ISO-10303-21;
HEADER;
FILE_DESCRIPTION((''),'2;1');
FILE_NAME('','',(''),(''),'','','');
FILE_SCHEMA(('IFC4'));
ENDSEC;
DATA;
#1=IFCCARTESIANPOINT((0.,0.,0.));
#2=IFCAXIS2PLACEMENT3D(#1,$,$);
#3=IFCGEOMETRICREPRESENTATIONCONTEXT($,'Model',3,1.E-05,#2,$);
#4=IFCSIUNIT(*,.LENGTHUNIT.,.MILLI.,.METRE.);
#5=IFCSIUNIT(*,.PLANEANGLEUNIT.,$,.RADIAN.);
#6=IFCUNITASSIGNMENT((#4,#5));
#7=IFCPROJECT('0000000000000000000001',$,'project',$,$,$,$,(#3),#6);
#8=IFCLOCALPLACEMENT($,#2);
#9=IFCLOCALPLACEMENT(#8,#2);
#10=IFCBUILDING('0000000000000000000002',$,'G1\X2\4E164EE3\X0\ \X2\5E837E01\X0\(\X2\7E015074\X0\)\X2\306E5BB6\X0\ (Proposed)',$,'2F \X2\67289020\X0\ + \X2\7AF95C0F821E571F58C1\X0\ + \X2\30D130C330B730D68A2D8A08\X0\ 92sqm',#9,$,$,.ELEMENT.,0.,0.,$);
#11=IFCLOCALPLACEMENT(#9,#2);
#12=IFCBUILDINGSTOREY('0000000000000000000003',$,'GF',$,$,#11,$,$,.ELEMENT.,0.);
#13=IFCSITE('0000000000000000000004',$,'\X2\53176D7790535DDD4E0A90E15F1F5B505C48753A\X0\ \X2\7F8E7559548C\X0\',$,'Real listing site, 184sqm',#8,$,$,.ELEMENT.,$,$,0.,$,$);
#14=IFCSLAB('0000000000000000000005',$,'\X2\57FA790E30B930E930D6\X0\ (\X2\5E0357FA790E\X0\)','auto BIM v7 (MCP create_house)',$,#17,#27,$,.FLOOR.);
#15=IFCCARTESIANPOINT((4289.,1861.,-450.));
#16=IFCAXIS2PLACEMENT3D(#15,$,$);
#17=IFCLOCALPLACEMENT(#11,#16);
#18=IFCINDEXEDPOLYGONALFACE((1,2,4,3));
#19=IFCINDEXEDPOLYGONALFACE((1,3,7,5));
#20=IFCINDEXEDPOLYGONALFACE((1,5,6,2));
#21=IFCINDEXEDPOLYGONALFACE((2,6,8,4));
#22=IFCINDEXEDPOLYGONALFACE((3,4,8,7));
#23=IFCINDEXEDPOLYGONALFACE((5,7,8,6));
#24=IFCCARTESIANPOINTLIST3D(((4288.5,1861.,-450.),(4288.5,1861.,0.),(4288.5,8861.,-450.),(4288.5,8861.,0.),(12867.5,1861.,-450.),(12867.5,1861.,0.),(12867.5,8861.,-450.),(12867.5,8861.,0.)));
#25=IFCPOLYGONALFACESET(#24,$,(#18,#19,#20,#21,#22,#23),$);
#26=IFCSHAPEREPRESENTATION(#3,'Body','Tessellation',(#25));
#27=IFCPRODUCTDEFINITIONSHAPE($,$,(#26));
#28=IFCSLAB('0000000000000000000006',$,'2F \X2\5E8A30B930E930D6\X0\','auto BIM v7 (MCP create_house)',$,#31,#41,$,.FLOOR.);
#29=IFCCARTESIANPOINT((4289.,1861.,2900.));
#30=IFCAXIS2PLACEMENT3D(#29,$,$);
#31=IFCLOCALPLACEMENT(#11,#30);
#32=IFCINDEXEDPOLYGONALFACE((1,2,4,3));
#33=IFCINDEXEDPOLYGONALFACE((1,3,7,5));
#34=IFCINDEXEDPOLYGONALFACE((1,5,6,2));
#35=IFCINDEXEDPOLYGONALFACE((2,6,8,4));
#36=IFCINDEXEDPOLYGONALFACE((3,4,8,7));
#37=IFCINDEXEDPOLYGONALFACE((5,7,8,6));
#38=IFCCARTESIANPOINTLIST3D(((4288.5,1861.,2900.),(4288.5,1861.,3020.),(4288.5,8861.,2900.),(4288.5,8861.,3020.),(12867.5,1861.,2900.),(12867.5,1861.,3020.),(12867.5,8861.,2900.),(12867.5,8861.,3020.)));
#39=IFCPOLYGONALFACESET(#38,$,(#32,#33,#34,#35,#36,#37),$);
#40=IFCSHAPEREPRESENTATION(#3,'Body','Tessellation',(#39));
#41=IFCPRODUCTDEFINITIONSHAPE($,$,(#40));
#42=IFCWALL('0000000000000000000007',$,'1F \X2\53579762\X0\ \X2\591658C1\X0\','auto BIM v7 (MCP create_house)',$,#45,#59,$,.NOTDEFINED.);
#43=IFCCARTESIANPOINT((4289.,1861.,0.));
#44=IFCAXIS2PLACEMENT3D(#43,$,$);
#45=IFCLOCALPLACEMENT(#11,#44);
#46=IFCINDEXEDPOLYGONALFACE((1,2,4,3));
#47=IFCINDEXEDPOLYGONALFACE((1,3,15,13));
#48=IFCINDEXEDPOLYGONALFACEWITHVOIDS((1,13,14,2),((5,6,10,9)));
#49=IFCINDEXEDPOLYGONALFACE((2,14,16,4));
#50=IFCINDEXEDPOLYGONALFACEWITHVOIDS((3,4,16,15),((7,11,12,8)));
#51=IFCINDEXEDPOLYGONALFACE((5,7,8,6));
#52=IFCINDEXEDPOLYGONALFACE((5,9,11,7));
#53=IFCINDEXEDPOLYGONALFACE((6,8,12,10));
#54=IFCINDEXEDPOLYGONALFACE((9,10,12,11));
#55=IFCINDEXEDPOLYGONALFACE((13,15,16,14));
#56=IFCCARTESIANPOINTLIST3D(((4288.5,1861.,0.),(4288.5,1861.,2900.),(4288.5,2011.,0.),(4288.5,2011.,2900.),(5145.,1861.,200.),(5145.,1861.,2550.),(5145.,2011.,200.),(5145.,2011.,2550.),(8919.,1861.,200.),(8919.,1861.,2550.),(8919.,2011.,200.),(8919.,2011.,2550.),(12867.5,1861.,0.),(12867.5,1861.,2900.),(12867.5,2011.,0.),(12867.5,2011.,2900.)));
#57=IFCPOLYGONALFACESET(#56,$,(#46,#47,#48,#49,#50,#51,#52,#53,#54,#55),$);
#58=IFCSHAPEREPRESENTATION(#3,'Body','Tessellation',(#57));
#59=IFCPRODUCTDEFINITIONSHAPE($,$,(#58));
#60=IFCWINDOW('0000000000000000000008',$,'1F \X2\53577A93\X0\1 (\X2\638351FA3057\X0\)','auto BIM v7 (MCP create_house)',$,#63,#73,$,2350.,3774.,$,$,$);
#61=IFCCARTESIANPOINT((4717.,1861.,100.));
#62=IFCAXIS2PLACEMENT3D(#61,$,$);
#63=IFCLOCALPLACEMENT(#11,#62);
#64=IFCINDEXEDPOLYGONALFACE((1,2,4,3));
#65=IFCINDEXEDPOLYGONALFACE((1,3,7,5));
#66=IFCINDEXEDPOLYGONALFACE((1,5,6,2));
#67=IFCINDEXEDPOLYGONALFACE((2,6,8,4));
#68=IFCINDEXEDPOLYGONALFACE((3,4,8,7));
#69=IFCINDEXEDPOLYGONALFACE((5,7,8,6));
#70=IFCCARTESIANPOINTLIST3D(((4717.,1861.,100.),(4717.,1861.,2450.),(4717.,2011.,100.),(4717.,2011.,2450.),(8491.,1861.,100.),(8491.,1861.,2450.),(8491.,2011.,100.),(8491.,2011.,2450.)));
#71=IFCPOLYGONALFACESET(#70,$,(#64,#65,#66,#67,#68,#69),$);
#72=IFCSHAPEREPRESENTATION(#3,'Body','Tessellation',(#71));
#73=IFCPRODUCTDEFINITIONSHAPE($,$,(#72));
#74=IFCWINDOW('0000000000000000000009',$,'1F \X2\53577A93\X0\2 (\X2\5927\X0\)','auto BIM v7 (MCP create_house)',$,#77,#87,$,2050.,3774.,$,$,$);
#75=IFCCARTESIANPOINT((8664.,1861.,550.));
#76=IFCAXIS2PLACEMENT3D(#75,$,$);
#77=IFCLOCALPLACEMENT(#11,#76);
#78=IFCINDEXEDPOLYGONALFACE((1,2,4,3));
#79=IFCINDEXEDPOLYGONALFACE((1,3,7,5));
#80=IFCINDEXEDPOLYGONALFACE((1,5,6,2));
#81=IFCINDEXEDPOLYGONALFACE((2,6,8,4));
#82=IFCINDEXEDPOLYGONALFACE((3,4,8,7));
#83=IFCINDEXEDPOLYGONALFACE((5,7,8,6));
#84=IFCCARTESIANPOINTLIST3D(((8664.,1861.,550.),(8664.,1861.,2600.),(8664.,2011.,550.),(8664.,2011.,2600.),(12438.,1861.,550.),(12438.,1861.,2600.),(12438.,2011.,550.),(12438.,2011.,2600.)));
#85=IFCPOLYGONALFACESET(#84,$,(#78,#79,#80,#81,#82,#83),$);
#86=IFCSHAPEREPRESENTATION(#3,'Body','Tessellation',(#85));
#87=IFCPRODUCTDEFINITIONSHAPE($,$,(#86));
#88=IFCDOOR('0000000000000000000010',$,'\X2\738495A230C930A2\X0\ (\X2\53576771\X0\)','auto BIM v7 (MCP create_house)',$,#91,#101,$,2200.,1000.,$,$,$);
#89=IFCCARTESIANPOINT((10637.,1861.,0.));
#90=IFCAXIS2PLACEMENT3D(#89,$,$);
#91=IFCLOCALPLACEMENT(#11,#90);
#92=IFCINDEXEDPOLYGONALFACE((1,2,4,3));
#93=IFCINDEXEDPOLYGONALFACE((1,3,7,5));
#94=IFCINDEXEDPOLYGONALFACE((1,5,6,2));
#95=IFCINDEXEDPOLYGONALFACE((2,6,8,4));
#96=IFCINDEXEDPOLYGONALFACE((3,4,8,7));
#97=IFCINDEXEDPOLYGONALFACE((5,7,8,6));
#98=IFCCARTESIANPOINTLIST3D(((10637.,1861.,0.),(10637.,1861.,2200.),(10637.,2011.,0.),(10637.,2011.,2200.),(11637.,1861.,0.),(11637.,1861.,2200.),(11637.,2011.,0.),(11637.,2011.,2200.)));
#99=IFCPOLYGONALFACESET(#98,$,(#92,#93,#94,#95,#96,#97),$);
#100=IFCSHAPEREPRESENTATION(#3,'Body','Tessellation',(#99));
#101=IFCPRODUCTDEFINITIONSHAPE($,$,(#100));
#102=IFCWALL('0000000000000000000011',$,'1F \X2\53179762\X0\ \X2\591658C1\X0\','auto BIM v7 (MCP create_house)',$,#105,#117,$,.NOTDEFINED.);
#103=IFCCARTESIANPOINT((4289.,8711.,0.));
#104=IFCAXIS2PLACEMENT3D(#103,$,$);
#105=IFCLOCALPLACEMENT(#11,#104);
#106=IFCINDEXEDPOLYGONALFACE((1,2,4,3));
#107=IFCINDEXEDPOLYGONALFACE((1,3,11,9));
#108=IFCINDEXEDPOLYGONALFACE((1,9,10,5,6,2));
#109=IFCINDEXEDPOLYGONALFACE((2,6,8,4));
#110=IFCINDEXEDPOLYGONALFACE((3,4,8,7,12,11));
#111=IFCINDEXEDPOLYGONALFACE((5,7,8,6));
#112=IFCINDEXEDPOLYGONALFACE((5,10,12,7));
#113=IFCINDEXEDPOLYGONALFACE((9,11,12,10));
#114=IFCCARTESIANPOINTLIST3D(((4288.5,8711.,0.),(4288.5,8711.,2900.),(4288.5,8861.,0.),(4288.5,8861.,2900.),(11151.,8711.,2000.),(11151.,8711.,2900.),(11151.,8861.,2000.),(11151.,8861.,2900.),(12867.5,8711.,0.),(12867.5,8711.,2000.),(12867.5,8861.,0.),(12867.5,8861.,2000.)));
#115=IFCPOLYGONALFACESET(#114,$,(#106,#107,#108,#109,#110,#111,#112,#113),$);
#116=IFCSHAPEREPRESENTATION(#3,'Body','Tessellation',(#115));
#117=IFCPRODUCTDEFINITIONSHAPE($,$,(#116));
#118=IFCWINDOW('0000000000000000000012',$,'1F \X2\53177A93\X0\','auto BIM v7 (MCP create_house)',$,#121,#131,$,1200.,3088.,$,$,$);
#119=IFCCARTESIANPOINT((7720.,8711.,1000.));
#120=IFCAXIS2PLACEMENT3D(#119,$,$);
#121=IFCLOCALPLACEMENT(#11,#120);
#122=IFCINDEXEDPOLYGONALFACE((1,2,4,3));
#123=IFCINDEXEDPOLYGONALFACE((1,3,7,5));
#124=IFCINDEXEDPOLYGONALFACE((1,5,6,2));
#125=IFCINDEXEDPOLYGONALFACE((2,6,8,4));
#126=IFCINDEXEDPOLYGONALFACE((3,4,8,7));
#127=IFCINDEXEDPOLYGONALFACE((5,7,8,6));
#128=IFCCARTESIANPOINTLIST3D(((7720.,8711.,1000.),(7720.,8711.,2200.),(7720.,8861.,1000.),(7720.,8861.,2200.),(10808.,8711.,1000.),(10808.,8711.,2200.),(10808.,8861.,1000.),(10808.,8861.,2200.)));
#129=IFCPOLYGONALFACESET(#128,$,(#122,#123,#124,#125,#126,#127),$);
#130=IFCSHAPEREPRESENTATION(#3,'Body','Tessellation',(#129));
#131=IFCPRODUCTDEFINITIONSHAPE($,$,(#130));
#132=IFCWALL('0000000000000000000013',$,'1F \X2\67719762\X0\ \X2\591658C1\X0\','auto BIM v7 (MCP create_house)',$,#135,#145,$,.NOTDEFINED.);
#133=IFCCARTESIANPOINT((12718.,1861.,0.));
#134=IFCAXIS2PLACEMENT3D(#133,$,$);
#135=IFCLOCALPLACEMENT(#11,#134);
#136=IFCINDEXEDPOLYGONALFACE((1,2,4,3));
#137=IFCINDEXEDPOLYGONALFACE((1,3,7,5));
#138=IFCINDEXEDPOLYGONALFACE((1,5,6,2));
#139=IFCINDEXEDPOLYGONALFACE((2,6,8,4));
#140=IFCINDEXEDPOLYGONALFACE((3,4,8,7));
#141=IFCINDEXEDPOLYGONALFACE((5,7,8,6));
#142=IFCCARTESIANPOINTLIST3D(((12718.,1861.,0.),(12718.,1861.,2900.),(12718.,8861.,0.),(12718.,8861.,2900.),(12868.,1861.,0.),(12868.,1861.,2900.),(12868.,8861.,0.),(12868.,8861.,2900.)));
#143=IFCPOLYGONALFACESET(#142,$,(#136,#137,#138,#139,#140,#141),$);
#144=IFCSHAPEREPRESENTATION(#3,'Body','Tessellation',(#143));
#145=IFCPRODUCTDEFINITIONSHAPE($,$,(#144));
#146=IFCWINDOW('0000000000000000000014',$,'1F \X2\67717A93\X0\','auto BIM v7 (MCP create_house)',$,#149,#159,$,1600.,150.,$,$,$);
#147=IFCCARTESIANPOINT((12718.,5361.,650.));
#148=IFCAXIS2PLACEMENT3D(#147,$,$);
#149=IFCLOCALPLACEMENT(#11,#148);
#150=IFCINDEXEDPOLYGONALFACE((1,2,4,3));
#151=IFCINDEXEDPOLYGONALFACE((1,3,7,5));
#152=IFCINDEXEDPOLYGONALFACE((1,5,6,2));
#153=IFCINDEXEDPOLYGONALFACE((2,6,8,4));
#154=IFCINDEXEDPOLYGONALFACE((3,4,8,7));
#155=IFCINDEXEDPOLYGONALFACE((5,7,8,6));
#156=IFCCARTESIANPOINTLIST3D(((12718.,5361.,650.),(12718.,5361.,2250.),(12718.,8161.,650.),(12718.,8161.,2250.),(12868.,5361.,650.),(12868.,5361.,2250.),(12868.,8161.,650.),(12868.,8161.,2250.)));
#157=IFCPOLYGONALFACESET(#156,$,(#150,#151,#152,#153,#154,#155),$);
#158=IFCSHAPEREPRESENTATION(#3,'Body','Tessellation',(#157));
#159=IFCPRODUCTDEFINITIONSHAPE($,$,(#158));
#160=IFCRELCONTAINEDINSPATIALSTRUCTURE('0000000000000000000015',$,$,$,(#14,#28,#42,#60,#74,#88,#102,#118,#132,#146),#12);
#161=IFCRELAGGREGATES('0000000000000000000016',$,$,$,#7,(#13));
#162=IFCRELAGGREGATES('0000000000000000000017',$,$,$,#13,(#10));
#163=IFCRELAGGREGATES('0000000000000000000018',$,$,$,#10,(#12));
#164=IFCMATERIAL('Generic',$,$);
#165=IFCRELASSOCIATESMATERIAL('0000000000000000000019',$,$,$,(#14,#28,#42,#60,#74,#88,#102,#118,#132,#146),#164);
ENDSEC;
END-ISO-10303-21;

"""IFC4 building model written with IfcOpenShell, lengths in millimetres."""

from ifc_helpers import new_model, si_unit, frame, frame_2d, origin, place, context, project, spatial, rectangle, extrude, material, element, fill, save


model = new_model("IFC4")

# Units and contexts
model_context = context("Model", 3, precision=1e-05, world=origin())
ifc_project = project(units=[si_unit("LENGTHUNIT", "METRE", prefix="MILLI"), si_unit("PLANEANGLEUNIT", "RADIAN")], contexts=[model_context])

# Site, building, storey
site_placement = place(None, origin())
site = spatial("IfcSite", under=ifc_project, at=site_placement, Name="北海道川上郡弟子屈町 美留和", ObjectType="Real listing site, 184sqm", CompositionType="ELEMENT", RefElevation=0.0)
building_placement = place(site_placement, origin())
building = spatial("IfcBuilding", under=site, at=building_placement, Name="G1世代 広縁(縁側)の家 (Proposed)", ObjectType="2F 木造 + 竹小舞土壁 + パッシブ設計 92sqm", CompositionType="ELEMENT", ElevationOfRefHeight=0.0, ElevationOfTerrain=0.0)
storey_placement = place(building_placement, origin())
storey = spatial("IfcBuildingStorey", under=building, at=storey_placement, Name="GF", CompositionType="ELEMENT", Elevation=0.0)

# Slabs
ifc_material = material(Name="Generic")
slab_1_placement = place(storey_placement, frame((4289.0, 1861.0, -450.0)))
element("IfcSlab", 1, at=slab_1_placement, inside=storey, material=ifc_material, Name="基礎スラブ (布基礎)", Description="auto BIM v7 (MCP create_house)", PredefinedType="FLOOR", context=model_context, shape_type="SweptSolid", body=[
    extrude(rectangle(XDim=8579.0, YDim=7000.0, at=frame_2d((4289.0, 3500.0))), frame((4289.0, 1861.0, -450.0)), (0.0, 0.0, 1.0), 450.0),
])
slab_2_placement = place(storey_placement, frame((4289.0, 1861.0, 2900.0)))
element("IfcSlab", 2, at=slab_2_placement, inside=storey, material=ifc_material, Name="2F 床スラブ", Description="auto BIM v7 (MCP create_house)", PredefinedType="FLOOR", context=model_context, shape_type="SweptSolid", body=[
    extrude(rectangle(XDim=8579.0, YDim=7000.0, at=frame_2d((4289.0, 3500.0))), frame((4289.0, 1861.0, 2900.0)), (0.0, 0.0, 1.0), 120.0),
])

# Wall, openings, windows, door
wall_1_placement = place(storey_placement, frame((4289.0, 1861.0, 0.0)))
wall_1 = element("IfcWall", 3, at=wall_1_placement, inside=storey, material=ifc_material, Name="1F 南面 外壁", Description="auto BIM v7 (MCP create_house)", PredefinedType="NOTDEFINED", context=model_context, shape_type="SweptSolid", body=[
    extrude(rectangle(XDim=8579.0, YDim=150.0, at=frame_2d((4289.0, 75.0))), frame((4289.0, 1861.0, 0.0)), (0.0, 0.0, 1.0), 2900.0),
])
opening_1_placement = place(storey_placement, frame((4717.0, 1861.0, 100.0)))
opening_1 = element("IfcOpeningElement", 4, at=opening_1_placement, cuts=wall_1, PredefinedType="NOTDEFINED", context=model_context, shape_type="SweptSolid", body=[
    extrude(rectangle(XDim=3774.0, YDim=150.0, at=frame_2d((1887.0, 75.0))), frame((4717.0, 1861.0, 100.0)), (0.0, 0.0, 1.0), 2350.0),
])
opening_2_placement = place(storey_placement, frame((8664.0, 1861.0, 550.0)))
opening_2 = element("IfcOpeningElement", 5, at=opening_2_placement, cuts=wall_1, PredefinedType="NOTDEFINED", context=model_context, shape_type="SweptSolid", body=[
    extrude(rectangle(XDim=3774.0, YDim=150.0, at=frame_2d((1887.0, 75.0))), frame((8664.0, 1861.0, 550.0)), (0.0, 0.0, 1.0), 2050.0),
])
opening_3_placement = place(storey_placement, frame((10637.0, 1861.0, 0.0)))
opening_3 = element("IfcOpeningElement", 6, at=opening_3_placement, cuts=wall_1, PredefinedType="NOTDEFINED", context=model_context, shape_type="SweptSolid", body=[
    extrude(rectangle(XDim=1000.0, YDim=150.0, at=frame_2d((500.0, 75.0))), frame((10637.0, 1861.0, 0.0)), (0.0, 0.0, 1.0), 2200.0),
])
window_1_placement = place(storey_placement, frame((4717.0, 1861.0, 100.0)))
window_1 = element("IfcWindow", 7, at=window_1_placement, inside=storey, material=ifc_material, Name="1F 南窓1 (掃出し)", Description="auto BIM v7 (MCP create_house)", OverallHeight=2350.0, OverallWidth=3774.0, context=model_context, shape_type="SweptSolid", body=[
    extrude(rectangle(XDim=3774.0, YDim=150.0, at=frame_2d((1887.0, 75.0))), frame((4717.0, 1861.0, 100.0)), (0.0, 0.0, 1.0), 2350.0),
])
fill(opening_1, window_1)
window_2_placement = place(storey_placement, frame((8664.0, 1861.0, 550.0)))
window_2 = element("IfcWindow", 8, at=window_2_placement, inside=storey, material=ifc_material, Name="1F 南窓2 (大)", Description="auto BIM v7 (MCP create_house)", OverallHeight=2050.0, OverallWidth=3774.0, context=model_context, shape_type="SweptSolid", body=[
    extrude(rectangle(XDim=3774.0, YDim=150.0, at=frame_2d((1887.0, 75.0))), frame((8664.0, 1861.0, 550.0)), (0.0, 0.0, 1.0), 2050.0),
])
fill(opening_2, window_2)
door_placement = place(storey_placement, frame((10637.0, 1861.0, 0.0)))
door = element("IfcDoor", 9, at=door_placement, inside=storey, material=ifc_material, Name="玄関ドア (南東)", Description="auto BIM v7 (MCP create_house)", OverallHeight=2200.0, OverallWidth=1000.0, context=model_context, shape_type="SweptSolid", body=[
    extrude(rectangle(XDim=1000.0, YDim=150.0, at=frame_2d((500.0, 75.0))), frame((10637.0, 1861.0, 0.0)), (0.0, 0.0, 1.0), 2200.0),
])
fill(opening_3, door)

# Walls, openings, windows
wall_2_placement = place(storey_placement, frame((4289.0, 8711.0, 0.0)))
wall_2 = element("IfcWall", 10, at=wall_2_placement, inside=storey, material=ifc_material, Name="1F 北面 外壁", Description="auto BIM v7 (MCP create_house)", PredefinedType="NOTDEFINED", context=model_context, shape_type="SweptSolid", body=[
    extrude(rectangle(XDim=8579.0, YDim=150.0, at=frame_2d((4289.0, 75.0))), frame((4289.0, 8711.0, 0.0)), (0.0, 0.0, 1.0), 2900.0),
])
opening_4_placement = place(storey_placement, frame((7720.0, 8711.0, 1000.0)))
opening_4 = element("IfcOpeningElement", 11, at=opening_4_placement, cuts=wall_2, PredefinedType="NOTDEFINED", context=model_context, shape_type="SweptSolid", body=[
    extrude(rectangle(XDim=3088.0, YDim=150.0, at=frame_2d((1544.0, 75.0))), frame((7720.0, 8711.0, 1000.0)), (0.0, 0.0, 1.0), 1200.0),
])
window_3_placement = place(storey_placement, frame((7720.0, 8711.0, 1000.0)))
window_3 = element("IfcWindow", 12, at=window_3_placement, inside=storey, material=ifc_material, Name="1F 北窓", Description="auto BIM v7 (MCP create_house)", OverallHeight=1200.0, OverallWidth=3088.0, context=model_context, shape_type="SweptSolid", body=[
    extrude(rectangle(XDim=3088.0, YDim=150.0, at=frame_2d((1544.0, 75.0))), frame((7720.0, 8711.0, 1000.0)), (0.0, 0.0, 1.0), 1200.0),
])
fill(opening_4, window_3)
wall_3_placement = place(storey_placement, frame((12718.0, 1861.0, 0.0)))
wall_3 = element("IfcWall", 13, at=wall_3_placement, inside=storey, material=ifc_material, Name="1F 東面 外壁", Description="auto BIM v7 (MCP create_house)", PredefinedType="NOTDEFINED", context=model_context, shape_type="SweptSolid", body=[
    extrude(rectangle(XDim=150.0, YDim=7000.0, at=frame_2d((75.0, 3500.0))), frame((12718.0, 1861.0, 0.0)), (0.0, 0.0, 1.0), 2900.0),
])
opening_5_placement = place(storey_placement, frame((12718.0, 5361.0, 650.0)))
opening_5 = element("IfcOpeningElement", 14, at=opening_5_placement, cuts=wall_3, PredefinedType="NOTDEFINED", context=model_context, shape_type="SweptSolid", body=[
    extrude(rectangle(XDim=150.0, YDim=2800.0, at=frame_2d((75.0, 1400.0))), frame((12718.0, 5361.0, 650.0)), (0.0, 0.0, 1.0), 1600.0),
])
window_4_placement = place(storey_placement, frame((12718.0, 5361.0, 650.0)))
window_4 = element("IfcWindow", 15, at=window_4_placement, inside=storey, material=ifc_material, Name="1F 東窓", Description="auto BIM v7 (MCP create_house)", OverallHeight=1600.0, OverallWidth=150.0, context=model_context, shape_type="SweptSolid", body=[
    extrude(rectangle(XDim=150.0, YDim=2800.0, at=frame_2d((75.0, 1400.0))), frame((12718.0, 5361.0, 650.0)), (0.0, 0.0, 1.0), 1600.0),
])
fill(opening_5, window_4)

save(model, "model.ifc")
